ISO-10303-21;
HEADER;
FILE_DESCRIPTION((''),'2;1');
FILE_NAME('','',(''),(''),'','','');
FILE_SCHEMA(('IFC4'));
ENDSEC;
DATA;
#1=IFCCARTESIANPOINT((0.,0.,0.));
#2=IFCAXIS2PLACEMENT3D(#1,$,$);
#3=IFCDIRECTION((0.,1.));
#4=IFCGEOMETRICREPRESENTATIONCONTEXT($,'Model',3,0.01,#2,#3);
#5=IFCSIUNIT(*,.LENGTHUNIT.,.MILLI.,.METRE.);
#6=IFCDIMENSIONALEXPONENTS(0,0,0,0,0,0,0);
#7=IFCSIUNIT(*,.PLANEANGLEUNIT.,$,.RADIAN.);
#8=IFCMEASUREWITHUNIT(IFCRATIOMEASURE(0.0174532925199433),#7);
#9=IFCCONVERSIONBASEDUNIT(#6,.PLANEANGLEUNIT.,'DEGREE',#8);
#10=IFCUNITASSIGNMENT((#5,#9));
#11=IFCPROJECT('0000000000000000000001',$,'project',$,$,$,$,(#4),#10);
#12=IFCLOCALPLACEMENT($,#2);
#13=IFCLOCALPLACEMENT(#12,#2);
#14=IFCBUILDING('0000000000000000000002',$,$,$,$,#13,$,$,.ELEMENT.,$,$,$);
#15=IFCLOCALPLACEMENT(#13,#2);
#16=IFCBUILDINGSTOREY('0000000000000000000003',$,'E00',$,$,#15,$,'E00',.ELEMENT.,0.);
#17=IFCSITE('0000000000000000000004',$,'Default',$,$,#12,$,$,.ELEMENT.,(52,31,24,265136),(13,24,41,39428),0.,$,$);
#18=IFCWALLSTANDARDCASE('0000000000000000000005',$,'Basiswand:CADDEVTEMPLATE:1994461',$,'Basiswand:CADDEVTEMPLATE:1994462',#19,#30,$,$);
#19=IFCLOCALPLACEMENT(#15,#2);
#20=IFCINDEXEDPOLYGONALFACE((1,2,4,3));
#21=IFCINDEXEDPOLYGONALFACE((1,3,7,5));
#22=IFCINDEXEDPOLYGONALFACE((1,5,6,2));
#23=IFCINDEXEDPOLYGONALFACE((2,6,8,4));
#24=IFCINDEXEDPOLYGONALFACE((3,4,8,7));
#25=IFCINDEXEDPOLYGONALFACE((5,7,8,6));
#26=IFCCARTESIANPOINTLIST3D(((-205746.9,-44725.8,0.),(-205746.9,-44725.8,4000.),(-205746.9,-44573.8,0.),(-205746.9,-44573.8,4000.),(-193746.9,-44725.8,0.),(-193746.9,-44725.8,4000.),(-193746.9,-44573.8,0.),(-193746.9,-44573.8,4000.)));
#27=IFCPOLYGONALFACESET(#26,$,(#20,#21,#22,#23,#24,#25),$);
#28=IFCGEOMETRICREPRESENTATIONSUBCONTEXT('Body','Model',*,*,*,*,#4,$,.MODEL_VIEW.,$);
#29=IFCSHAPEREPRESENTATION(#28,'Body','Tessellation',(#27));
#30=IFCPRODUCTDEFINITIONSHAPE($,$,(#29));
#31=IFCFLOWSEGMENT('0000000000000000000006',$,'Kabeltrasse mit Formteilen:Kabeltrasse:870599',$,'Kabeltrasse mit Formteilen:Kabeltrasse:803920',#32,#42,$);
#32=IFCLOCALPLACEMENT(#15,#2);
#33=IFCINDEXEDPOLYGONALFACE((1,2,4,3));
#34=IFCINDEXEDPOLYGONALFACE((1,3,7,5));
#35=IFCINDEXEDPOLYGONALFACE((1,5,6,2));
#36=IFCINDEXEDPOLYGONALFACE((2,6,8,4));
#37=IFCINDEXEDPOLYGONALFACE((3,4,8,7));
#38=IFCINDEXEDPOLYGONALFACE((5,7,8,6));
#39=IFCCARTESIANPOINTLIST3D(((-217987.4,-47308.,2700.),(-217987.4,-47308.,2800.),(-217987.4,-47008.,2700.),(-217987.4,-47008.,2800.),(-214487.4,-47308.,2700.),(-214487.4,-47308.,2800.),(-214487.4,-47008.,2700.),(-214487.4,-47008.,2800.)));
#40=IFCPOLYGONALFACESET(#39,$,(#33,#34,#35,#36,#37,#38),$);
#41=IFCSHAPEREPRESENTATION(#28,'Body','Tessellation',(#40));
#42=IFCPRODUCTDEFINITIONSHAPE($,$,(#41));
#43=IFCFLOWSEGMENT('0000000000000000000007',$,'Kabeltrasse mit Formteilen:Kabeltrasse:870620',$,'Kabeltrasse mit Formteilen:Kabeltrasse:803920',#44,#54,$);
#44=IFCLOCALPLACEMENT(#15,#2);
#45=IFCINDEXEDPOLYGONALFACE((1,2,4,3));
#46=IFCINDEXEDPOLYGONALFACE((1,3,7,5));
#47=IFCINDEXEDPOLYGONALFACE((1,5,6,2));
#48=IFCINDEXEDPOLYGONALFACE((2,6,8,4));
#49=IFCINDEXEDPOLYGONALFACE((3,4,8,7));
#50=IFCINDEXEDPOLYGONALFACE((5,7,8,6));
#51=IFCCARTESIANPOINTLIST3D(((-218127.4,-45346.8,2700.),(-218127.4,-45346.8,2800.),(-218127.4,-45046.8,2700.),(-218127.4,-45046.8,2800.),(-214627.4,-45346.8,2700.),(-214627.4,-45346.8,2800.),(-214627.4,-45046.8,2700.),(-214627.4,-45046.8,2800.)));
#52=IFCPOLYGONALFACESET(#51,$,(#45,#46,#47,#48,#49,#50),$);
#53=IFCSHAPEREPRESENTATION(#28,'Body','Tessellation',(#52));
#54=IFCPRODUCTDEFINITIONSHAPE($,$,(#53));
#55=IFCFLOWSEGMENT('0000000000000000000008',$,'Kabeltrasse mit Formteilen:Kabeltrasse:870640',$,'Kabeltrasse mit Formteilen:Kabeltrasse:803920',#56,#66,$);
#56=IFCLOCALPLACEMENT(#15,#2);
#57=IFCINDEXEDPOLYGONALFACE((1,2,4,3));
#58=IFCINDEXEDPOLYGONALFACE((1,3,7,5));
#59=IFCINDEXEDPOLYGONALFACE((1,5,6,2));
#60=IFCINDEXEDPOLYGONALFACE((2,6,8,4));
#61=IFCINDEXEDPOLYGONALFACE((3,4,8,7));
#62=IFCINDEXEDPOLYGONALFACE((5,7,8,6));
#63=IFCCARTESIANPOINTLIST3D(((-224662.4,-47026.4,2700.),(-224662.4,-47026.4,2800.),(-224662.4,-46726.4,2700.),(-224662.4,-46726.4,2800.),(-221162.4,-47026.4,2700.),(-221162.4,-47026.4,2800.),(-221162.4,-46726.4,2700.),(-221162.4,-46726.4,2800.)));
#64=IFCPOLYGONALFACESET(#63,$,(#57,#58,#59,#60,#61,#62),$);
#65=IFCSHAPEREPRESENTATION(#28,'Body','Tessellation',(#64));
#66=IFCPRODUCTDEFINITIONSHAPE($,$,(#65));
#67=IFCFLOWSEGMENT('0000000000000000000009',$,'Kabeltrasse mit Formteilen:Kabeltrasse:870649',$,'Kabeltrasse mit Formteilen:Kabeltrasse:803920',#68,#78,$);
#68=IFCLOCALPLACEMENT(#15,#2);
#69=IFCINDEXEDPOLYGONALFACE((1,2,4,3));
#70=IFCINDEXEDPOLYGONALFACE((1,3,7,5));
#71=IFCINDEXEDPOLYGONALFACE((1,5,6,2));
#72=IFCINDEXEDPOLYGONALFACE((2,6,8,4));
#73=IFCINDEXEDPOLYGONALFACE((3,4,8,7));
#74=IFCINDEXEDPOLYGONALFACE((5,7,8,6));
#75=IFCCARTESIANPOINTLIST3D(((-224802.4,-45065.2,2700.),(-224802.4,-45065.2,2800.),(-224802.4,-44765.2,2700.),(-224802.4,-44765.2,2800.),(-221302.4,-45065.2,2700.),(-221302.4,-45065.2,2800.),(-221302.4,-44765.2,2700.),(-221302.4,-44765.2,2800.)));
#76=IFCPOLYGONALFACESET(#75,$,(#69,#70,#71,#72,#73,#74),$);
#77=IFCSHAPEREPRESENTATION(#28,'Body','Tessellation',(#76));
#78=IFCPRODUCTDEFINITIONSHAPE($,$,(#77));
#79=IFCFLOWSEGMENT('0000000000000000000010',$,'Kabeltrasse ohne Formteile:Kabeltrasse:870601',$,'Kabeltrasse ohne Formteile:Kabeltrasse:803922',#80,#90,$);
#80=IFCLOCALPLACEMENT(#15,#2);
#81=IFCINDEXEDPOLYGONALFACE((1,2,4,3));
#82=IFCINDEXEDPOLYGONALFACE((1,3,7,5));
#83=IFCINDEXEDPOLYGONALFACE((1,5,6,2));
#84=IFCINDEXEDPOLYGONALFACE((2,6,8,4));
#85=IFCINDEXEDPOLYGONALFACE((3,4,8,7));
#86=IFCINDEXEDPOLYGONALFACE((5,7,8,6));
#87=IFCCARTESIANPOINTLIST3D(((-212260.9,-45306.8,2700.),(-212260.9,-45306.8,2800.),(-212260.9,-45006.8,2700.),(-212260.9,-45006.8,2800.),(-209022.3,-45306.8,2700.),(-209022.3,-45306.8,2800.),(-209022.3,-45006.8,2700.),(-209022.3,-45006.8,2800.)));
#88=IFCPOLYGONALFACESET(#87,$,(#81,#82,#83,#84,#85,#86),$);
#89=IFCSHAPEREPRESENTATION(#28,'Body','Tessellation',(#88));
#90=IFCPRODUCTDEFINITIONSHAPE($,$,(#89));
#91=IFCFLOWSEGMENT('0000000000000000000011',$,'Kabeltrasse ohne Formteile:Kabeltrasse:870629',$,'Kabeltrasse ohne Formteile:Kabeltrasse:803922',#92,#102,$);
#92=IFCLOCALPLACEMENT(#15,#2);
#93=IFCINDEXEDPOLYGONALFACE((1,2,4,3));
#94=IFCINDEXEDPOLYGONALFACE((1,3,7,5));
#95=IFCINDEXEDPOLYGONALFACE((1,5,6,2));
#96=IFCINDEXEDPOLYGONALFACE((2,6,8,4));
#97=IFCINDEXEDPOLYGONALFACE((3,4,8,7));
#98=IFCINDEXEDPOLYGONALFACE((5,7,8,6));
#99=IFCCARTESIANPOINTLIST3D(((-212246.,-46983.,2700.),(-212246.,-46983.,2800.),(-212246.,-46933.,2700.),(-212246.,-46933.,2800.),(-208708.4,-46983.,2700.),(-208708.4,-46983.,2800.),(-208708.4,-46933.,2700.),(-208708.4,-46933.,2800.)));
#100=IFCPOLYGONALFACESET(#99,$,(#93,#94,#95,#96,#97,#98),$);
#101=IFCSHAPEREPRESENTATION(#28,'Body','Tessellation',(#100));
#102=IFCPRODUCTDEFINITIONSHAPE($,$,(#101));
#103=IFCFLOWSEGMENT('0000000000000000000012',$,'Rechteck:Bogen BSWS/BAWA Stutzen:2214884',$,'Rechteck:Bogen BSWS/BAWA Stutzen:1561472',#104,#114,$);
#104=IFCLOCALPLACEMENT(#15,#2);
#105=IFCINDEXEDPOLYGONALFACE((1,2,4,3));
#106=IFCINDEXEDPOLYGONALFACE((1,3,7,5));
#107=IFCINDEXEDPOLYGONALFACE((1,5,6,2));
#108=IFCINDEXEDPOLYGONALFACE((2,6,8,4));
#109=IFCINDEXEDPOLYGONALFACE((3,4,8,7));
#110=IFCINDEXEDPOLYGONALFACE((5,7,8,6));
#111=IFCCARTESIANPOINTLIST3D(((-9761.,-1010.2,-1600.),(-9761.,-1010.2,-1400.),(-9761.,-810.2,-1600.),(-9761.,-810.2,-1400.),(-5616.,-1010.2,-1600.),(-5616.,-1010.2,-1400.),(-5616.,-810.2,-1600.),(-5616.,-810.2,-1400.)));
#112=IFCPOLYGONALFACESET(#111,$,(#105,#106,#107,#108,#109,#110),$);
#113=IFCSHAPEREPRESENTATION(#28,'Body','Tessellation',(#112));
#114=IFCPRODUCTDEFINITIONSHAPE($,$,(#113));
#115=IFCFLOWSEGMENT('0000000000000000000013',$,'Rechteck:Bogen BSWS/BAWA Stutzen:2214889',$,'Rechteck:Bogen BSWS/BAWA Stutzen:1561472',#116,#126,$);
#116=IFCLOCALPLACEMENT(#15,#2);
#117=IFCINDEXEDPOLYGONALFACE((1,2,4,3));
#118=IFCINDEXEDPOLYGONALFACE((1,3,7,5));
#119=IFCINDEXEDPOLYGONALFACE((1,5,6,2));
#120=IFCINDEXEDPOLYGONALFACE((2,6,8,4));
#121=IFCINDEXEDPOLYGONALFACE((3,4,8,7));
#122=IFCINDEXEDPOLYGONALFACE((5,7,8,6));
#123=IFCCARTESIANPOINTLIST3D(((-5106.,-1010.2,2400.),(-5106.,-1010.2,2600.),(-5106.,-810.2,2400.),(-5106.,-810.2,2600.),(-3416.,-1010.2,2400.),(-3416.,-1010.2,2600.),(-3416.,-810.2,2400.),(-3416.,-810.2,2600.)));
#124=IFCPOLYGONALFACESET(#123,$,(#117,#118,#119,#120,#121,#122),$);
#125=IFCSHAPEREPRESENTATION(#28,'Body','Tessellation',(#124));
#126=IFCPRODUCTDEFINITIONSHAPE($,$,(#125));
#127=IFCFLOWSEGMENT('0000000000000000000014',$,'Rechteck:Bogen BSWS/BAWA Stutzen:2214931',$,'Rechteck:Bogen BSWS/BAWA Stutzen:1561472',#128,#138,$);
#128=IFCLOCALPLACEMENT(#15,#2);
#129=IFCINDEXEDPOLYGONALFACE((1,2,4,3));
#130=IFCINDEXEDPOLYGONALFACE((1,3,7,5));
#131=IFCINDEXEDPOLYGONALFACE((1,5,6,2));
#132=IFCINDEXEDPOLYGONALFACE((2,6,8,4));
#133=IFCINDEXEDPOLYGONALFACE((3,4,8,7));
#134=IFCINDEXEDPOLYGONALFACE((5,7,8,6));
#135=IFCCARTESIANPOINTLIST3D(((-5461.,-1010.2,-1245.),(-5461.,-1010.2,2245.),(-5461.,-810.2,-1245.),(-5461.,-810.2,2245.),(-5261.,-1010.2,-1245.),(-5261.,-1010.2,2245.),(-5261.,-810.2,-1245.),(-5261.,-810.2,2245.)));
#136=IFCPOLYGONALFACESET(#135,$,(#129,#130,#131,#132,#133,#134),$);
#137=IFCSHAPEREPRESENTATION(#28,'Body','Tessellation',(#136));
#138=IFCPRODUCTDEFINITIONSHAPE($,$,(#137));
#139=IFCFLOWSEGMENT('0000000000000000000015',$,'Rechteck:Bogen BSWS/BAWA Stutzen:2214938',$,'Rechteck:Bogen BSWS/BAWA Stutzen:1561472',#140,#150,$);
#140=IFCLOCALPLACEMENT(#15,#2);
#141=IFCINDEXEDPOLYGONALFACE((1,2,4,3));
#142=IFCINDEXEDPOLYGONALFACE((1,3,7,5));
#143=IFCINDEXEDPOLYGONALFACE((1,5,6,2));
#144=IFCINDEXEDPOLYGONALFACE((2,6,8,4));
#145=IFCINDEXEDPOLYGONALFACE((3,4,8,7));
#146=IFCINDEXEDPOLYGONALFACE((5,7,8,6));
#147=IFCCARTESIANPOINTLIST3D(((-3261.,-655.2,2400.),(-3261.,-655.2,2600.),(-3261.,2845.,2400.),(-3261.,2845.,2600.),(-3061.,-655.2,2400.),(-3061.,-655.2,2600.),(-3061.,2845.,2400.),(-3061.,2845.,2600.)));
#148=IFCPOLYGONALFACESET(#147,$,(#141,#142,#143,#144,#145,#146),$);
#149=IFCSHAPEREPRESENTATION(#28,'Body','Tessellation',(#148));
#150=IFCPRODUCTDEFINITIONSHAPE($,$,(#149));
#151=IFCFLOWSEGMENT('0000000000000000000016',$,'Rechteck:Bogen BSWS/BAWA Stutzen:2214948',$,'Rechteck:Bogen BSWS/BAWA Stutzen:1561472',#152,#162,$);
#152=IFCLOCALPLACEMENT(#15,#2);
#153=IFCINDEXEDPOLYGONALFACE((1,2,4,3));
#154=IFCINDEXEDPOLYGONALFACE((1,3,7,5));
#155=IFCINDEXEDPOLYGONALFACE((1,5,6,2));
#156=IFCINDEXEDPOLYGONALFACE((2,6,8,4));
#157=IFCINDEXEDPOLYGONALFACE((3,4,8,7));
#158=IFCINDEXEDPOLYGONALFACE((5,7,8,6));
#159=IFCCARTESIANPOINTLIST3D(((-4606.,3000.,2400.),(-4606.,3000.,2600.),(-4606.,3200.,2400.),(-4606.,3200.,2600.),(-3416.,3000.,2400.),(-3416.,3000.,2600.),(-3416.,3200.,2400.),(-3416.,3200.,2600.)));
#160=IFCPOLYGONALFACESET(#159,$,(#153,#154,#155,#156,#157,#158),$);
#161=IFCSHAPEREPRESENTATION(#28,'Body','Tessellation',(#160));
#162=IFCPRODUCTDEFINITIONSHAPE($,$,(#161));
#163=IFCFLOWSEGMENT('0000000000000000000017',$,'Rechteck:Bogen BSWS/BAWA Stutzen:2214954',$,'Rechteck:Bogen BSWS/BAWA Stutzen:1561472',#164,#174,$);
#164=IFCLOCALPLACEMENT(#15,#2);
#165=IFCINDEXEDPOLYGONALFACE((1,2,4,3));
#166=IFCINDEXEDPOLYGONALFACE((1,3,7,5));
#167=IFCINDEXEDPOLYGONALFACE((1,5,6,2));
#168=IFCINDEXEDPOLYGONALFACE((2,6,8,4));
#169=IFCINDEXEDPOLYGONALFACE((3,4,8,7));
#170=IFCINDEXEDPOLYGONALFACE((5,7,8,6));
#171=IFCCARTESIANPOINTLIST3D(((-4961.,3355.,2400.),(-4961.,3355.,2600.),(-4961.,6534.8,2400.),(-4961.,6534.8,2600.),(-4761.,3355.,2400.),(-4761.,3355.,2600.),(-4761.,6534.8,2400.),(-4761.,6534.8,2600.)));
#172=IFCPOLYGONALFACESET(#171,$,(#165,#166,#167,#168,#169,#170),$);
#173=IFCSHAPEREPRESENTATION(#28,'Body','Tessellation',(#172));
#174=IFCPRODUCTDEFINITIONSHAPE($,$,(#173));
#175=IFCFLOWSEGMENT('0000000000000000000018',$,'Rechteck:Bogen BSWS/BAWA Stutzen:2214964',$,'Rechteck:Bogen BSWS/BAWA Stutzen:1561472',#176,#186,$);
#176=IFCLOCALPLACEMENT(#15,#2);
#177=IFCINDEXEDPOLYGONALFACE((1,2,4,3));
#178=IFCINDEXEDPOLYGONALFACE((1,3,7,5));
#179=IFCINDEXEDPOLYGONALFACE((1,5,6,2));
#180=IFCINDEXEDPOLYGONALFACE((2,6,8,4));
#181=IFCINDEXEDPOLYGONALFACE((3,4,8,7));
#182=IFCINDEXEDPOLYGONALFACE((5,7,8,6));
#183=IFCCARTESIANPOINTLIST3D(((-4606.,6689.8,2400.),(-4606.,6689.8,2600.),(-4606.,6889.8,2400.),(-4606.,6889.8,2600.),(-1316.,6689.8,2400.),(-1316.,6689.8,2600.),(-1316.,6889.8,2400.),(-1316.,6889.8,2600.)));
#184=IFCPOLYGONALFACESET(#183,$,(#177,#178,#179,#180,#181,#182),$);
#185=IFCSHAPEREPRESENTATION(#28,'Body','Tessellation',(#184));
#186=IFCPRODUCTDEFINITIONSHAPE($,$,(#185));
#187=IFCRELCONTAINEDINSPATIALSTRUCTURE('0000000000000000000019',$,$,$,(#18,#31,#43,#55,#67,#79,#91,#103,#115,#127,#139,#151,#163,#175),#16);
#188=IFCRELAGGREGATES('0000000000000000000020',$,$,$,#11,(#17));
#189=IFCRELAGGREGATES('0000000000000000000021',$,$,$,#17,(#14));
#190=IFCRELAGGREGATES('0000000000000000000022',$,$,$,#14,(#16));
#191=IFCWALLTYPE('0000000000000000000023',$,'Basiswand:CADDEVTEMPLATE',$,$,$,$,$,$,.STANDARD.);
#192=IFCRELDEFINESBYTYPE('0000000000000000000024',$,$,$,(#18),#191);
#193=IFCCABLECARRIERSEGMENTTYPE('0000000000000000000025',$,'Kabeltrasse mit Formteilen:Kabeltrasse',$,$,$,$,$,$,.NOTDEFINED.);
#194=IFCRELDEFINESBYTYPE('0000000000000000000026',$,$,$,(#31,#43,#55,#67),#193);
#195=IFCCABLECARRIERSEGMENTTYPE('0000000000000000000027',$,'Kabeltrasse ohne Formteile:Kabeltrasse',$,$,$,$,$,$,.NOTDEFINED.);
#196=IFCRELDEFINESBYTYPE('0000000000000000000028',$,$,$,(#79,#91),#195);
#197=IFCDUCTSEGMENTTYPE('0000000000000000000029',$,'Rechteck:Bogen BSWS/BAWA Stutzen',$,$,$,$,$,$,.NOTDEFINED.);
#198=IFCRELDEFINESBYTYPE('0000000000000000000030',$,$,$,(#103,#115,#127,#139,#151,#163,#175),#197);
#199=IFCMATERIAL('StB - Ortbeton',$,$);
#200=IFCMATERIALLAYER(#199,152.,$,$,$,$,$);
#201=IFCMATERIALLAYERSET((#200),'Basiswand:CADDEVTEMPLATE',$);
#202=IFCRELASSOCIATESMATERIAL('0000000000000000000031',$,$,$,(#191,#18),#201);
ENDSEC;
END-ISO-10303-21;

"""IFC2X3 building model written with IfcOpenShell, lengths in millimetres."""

from ifc_helpers import new_model, entity, si_unit, converted_unit, direction, frame, frame_2d, origin, origin_2d_with_axis, place, context, subcontext, project, spatial, rectangle, extrude, material, layer, layer_set, layer_usage, type_object, element, save


model = new_model("IFC2X3")

# Units and contexts
model_context = context("Model", 3, precision=0.01, world=origin(), true_north=direction((0.0, 1.0)))
body_context = subcontext(model_context, "Body", "Model", "MODEL_VIEW")
ifc_project = project(units=[si_unit("LENGTHUNIT", "METRE", prefix="MILLI"), converted_unit("PLANEANGLEUNIT", "DEGREE", entity("IfcRatioMeasure", 0.0174532925199433), si_unit("PLANEANGLEUNIT", "RADIAN"), dimensions=[0, 0, 0, 0, 0, 0, 0])], contexts=[model_context])

# Site, building, storey
site_placement = place(None, origin())
site = spatial("IfcSite", under=ifc_project, at=site_placement, Name="Default", CompositionType="ELEMENT", RefLatitude=(52, 31, 24, 265136), RefLongitude=(13, 24, 41, 39428), RefElevation=0.0)
building_placement = place(site_placement, origin())
building = spatial("IfcBuilding", under=site, at=building_placement, CompositionType="ELEMENT")
storey_placement = place(building_placement, origin())
storey = spatial("IfcBuildingStorey", under=building, at=storey_placement, Name="E00", LongName="E00", CompositionType="ELEMENT", Elevation=0.0)

# Wall
ifc_material = material(Name="StB - Ortbeton")
ifc_layer = layer(ifc_material, 152.0)
ifc_layer_set = layer_set([ifc_layer], Name="Basiswand:CADDEVTEMPLATE")
ifc_layer_usage = layer_usage(ifc_layer_set, "AXIS2", "NEGATIVE", 76.0)
wall_type = type_object("IfcWallType", Name="Basiswand:CADDEVTEMPLATE", PredefinedType="STANDARD", material=ifc_layer_set)
wall_placement = place(storey_placement, frame((-205746.9, -44649.8, 0.0)))
element("IfcWallStandardCase", 1, at=wall_placement, inside=storey, type_object=wall_type, material=ifc_layer_usage, Name="Basiswand:CADDEVTEMPLATE:1994461", ObjectType="Basiswand:CADDEVTEMPLATE:1994462", context=body_context, shape_type="SweptSolid", body=[
    extrude(rectangle(XDim=12000.0, YDim=152.0, at=frame_2d((6000.0, 0.0), x_axis=(-1.0, 0.0))), origin(), (0.0, 0.0, 1.0), 4000.0),
])

# Flow segments
cable_carrier_segment_type_1 = type_object("IfcCableCarrierSegmentType", Name="Kabeltrasse mit Formteilen:Kabeltrasse", PredefinedType="NOTDEFINED")
flow_segment_1_placement = place(storey_placement, origin())
element("IfcFlowSegment", 2, at=flow_segment_1_placement, inside=storey, type_object=cable_carrier_segment_type_1, Name="Kabeltrasse mit Formteilen:Kabeltrasse:870599", ObjectType="Kabeltrasse mit Formteilen:Kabeltrasse:803920", context=body_context, shape_type="SweptSolid", body=[
    extrude(rectangle(XDim=3500.0, YDim=300.0, at=frame_2d((0.0, 0.0), x_axis=(1.0, 0.0))), frame((-216237.4, -47158.0, 2700.0)), (0.0, 0.0, 1.0), 100.0),
])
flow_segment_2_placement = place(storey_placement, origin())
element("IfcFlowSegment", 3, at=flow_segment_2_placement, inside=storey, type_object=cable_carrier_segment_type_1, Name="Kabeltrasse mit Formteilen:Kabeltrasse:870620", ObjectType="Kabeltrasse mit Formteilen:Kabeltrasse:803920", context=body_context, shape_type="SweptSolid", body=[
    extrude(rectangle(XDim=3500.0, YDim=300.0, at=frame_2d((0.0, 0.0), x_axis=(1.0, 0.0))), frame((-216377.4, -45196.8, 2700.0)), (0.0, 0.0, 1.0), 100.0),
])
flow_segment_3_placement = place(storey_placement, origin())
element("IfcFlowSegment", 4, at=flow_segment_3_placement, inside=storey, type_object=cable_carrier_segment_type_1, Name="Kabeltrasse mit Formteilen:Kabeltrasse:870640", ObjectType="Kabeltrasse mit Formteilen:Kabeltrasse:803920", context=body_context, shape_type="SweptSolid", body=[
    extrude(rectangle(XDim=3500.0, YDim=300.0, at=frame_2d((0.0, 0.0), x_axis=(1.0, 0.0))), frame((-222912.4, -46876.4, 2700.0)), (0.0, 0.0, 1.0), 100.0),
])
flow_segment_4_placement = place(storey_placement, origin())
element("IfcFlowSegment", 5, at=flow_segment_4_placement, inside=storey, type_object=cable_carrier_segment_type_1, Name="Kabeltrasse mit Formteilen:Kabeltrasse:870649", ObjectType="Kabeltrasse mit Formteilen:Kabeltrasse:803920", context=body_context, shape_type="SweptSolid", body=[
    extrude(rectangle(XDim=3500.0, YDim=300.0, at=frame_2d((0.0, 0.0), x_axis=(1.0, 0.0))), frame((-223052.4, -44915.2, 2700.0)), (0.0, 0.0, 1.0), 100.0),
])
cable_carrier_segment_type_2 = type_object("IfcCableCarrierSegmentType", Name="Kabeltrasse ohne Formteile:Kabeltrasse", PredefinedType="NOTDEFINED")
flow_segment_5_placement = place(storey_placement, origin())
element("IfcFlowSegment", 6, at=flow_segment_5_placement, inside=storey, type_object=cable_carrier_segment_type_2, Name="Kabeltrasse ohne Formteile:Kabeltrasse:870601", ObjectType="Kabeltrasse ohne Formteile:Kabeltrasse:803922", context=body_context, shape_type="SweptSolid", body=[
    extrude(rectangle(XDim=3238.6, YDim=300.0, at=frame_2d((0.0, 0.0), x_axis=(1.0, 0.0))), frame((-210641.6, -45156.8, 2700.0), z_axis=(0.0, 0.0, 1.0), x_axis=(-1.0, 0.0, 0.0)), (0.0, 0.0, 1.0), 100.0),
])
flow_segment_6_placement = place(storey_placement, origin())
element("IfcFlowSegment", 7, at=flow_segment_6_placement, inside=storey, type_object=cable_carrier_segment_type_2, Name="Kabeltrasse ohne Formteile:Kabeltrasse:870629", ObjectType="Kabeltrasse ohne Formteile:Kabeltrasse:803922", context=body_context, shape_type="SweptSolid", body=[
    extrude(rectangle(XDim=3537.6, YDim=50.0, at=origin_2d_with_axis()), frame((-210477.2, -46958.0, 2700.0), z_axis=(0.0, 0.0, 1.0), x_axis=(-1.0, 0.0, 0.0)), (0.0, 0.0, 1.0), 100.0),
])
duct_segment_type = type_object("IfcDuctSegmentType", Name="Rechteck:Bogen BSWS/BAWA Stutzen", PredefinedType="NOTDEFINED")
flow_segment_7_placement = place(storey_placement, origin())
element("IfcFlowSegment", 8, at=flow_segment_7_placement, inside=storey, type_object=duct_segment_type, Name="Rechteck:Bogen BSWS/BAWA Stutzen:2214884", ObjectType="Rechteck:Bogen BSWS/BAWA Stutzen:1561472", context=body_context, shape_type="SweptSolid", body=[
    extrude(rectangle(XDim=4145.0, YDim=200.0, at=frame_2d((0.0, 0.0), x_axis=(1.0, 0.0))), frame((-7688.5, -910.2, -1600.0)), (0.0, 0.0, 1.0), 200.0),
])
flow_segment_8_placement = place(storey_placement, origin())
element("IfcFlowSegment", 9, at=flow_segment_8_placement, inside=storey, type_object=duct_segment_type, Name="Rechteck:Bogen BSWS/BAWA Stutzen:2214889", ObjectType="Rechteck:Bogen BSWS/BAWA Stutzen:1561472", context=body_context, shape_type="SweptSolid", body=[
    extrude(rectangle(XDim=1690.0, YDim=200.0, at=frame_2d((0.0, 0.0), x_axis=(1.0, 0.0))), frame((-4261.0, -910.2, 2400.0)), (0.0, 0.0, 1.0), 200.0),
])
flow_segment_9_placement = place(storey_placement, origin())
element("IfcFlowSegment", 10, at=flow_segment_9_placement, inside=storey, type_object=duct_segment_type, Name="Rechteck:Bogen BSWS/BAWA Stutzen:2214931", ObjectType="Rechteck:Bogen BSWS/BAWA Stutzen:1561472", context=body_context, shape_type="SweptSolid", body=[
    extrude(rectangle(XDim=200.0, YDim=200.0, at=origin_2d_with_axis()), frame((-5361.0, -910.2, -1245.0), z_axis=(0.0, 0.0, 1.0), x_axis=(-1.0, 0.0, 0.0)), (0.0, 0.0, 1.0), 3490.0),
])
flow_segment_10_placement = place(storey_placement, origin())
element("IfcFlowSegment", 11, at=flow_segment_10_placement, inside=storey, type_object=duct_segment_type, Name="Rechteck:Bogen BSWS/BAWA Stutzen:2214938", ObjectType="Rechteck:Bogen BSWS/BAWA Stutzen:1561472", context=body_context, shape_type="SweptSolid", body=[
    extrude(rectangle(XDim=3500.2, YDim=200.0, at=frame_2d((0.0, 0.0), x_axis=(1.0, 0.0))), frame((-3161.0, 1094.9, 2400.0), z_axis=(0.0, 0.0, 1.0), x_axis=(0.0, 1.0, 0.0)), (0.0, 0.0, 1.0), 200.0),
])
flow_segment_11_placement = place(storey_placement, origin())
element("IfcFlowSegment", 12, at=flow_segment_11_placement, inside=storey, type_object=duct_segment_type, Name="Rechteck:Bogen BSWS/BAWA Stutzen:2214948", ObjectType="Rechteck:Bogen BSWS/BAWA Stutzen:1561472", context=body_context, shape_type="SweptSolid", body=[
    extrude(rectangle(XDim=1190.0, YDim=200.0, at=frame_2d((0.0, 0.0), x_axis=(1.0, 0.0))), frame((-4011.0, 3100.0, 2400.0), z_axis=(0.0, 0.0, 1.0), x_axis=(-1.0, 0.0, 0.0)), (0.0, 0.0, 1.0), 200.0),
])
flow_segment_12_placement = place(storey_placement, origin())
element("IfcFlowSegment", 13, at=flow_segment_12_placement, inside=storey, type_object=duct_segment_type, Name="Rechteck:Bogen BSWS/BAWA Stutzen:2214954", ObjectType="Rechteck:Bogen BSWS/BAWA Stutzen:1561472", context=body_context, shape_type="SweptSolid", body=[
    extrude(rectangle(XDim=3179.8, YDim=200.0, at=frame_2d((0.0, 0.0), x_axis=(1.0, 0.0))), frame((-4861.0, 4944.9, 2400.0), z_axis=(0.0, 0.0, 1.0), x_axis=(0.0, 1.0, 0.0)), (0.0, 0.0, 1.0), 200.0),
])
flow_segment_13_placement = place(storey_placement, origin())
element("IfcFlowSegment", 14, at=flow_segment_13_placement, inside=storey, type_object=duct_segment_type, Name="Rechteck:Bogen BSWS/BAWA Stutzen:2214964", ObjectType="Rechteck:Bogen BSWS/BAWA Stutzen:1561472", context=body_context, shape_type="SweptSolid", body=[
    extrude(rectangle(XDim=3290.0, YDim=200.0, at=frame_2d((0.0, 0.0), x_axis=(1.0, 0.0))), frame((-2961.0, 6789.8, 2400.0)), (0.0, 0.0, 1.0), 200.0),
])

save(model, "model.ifc")
